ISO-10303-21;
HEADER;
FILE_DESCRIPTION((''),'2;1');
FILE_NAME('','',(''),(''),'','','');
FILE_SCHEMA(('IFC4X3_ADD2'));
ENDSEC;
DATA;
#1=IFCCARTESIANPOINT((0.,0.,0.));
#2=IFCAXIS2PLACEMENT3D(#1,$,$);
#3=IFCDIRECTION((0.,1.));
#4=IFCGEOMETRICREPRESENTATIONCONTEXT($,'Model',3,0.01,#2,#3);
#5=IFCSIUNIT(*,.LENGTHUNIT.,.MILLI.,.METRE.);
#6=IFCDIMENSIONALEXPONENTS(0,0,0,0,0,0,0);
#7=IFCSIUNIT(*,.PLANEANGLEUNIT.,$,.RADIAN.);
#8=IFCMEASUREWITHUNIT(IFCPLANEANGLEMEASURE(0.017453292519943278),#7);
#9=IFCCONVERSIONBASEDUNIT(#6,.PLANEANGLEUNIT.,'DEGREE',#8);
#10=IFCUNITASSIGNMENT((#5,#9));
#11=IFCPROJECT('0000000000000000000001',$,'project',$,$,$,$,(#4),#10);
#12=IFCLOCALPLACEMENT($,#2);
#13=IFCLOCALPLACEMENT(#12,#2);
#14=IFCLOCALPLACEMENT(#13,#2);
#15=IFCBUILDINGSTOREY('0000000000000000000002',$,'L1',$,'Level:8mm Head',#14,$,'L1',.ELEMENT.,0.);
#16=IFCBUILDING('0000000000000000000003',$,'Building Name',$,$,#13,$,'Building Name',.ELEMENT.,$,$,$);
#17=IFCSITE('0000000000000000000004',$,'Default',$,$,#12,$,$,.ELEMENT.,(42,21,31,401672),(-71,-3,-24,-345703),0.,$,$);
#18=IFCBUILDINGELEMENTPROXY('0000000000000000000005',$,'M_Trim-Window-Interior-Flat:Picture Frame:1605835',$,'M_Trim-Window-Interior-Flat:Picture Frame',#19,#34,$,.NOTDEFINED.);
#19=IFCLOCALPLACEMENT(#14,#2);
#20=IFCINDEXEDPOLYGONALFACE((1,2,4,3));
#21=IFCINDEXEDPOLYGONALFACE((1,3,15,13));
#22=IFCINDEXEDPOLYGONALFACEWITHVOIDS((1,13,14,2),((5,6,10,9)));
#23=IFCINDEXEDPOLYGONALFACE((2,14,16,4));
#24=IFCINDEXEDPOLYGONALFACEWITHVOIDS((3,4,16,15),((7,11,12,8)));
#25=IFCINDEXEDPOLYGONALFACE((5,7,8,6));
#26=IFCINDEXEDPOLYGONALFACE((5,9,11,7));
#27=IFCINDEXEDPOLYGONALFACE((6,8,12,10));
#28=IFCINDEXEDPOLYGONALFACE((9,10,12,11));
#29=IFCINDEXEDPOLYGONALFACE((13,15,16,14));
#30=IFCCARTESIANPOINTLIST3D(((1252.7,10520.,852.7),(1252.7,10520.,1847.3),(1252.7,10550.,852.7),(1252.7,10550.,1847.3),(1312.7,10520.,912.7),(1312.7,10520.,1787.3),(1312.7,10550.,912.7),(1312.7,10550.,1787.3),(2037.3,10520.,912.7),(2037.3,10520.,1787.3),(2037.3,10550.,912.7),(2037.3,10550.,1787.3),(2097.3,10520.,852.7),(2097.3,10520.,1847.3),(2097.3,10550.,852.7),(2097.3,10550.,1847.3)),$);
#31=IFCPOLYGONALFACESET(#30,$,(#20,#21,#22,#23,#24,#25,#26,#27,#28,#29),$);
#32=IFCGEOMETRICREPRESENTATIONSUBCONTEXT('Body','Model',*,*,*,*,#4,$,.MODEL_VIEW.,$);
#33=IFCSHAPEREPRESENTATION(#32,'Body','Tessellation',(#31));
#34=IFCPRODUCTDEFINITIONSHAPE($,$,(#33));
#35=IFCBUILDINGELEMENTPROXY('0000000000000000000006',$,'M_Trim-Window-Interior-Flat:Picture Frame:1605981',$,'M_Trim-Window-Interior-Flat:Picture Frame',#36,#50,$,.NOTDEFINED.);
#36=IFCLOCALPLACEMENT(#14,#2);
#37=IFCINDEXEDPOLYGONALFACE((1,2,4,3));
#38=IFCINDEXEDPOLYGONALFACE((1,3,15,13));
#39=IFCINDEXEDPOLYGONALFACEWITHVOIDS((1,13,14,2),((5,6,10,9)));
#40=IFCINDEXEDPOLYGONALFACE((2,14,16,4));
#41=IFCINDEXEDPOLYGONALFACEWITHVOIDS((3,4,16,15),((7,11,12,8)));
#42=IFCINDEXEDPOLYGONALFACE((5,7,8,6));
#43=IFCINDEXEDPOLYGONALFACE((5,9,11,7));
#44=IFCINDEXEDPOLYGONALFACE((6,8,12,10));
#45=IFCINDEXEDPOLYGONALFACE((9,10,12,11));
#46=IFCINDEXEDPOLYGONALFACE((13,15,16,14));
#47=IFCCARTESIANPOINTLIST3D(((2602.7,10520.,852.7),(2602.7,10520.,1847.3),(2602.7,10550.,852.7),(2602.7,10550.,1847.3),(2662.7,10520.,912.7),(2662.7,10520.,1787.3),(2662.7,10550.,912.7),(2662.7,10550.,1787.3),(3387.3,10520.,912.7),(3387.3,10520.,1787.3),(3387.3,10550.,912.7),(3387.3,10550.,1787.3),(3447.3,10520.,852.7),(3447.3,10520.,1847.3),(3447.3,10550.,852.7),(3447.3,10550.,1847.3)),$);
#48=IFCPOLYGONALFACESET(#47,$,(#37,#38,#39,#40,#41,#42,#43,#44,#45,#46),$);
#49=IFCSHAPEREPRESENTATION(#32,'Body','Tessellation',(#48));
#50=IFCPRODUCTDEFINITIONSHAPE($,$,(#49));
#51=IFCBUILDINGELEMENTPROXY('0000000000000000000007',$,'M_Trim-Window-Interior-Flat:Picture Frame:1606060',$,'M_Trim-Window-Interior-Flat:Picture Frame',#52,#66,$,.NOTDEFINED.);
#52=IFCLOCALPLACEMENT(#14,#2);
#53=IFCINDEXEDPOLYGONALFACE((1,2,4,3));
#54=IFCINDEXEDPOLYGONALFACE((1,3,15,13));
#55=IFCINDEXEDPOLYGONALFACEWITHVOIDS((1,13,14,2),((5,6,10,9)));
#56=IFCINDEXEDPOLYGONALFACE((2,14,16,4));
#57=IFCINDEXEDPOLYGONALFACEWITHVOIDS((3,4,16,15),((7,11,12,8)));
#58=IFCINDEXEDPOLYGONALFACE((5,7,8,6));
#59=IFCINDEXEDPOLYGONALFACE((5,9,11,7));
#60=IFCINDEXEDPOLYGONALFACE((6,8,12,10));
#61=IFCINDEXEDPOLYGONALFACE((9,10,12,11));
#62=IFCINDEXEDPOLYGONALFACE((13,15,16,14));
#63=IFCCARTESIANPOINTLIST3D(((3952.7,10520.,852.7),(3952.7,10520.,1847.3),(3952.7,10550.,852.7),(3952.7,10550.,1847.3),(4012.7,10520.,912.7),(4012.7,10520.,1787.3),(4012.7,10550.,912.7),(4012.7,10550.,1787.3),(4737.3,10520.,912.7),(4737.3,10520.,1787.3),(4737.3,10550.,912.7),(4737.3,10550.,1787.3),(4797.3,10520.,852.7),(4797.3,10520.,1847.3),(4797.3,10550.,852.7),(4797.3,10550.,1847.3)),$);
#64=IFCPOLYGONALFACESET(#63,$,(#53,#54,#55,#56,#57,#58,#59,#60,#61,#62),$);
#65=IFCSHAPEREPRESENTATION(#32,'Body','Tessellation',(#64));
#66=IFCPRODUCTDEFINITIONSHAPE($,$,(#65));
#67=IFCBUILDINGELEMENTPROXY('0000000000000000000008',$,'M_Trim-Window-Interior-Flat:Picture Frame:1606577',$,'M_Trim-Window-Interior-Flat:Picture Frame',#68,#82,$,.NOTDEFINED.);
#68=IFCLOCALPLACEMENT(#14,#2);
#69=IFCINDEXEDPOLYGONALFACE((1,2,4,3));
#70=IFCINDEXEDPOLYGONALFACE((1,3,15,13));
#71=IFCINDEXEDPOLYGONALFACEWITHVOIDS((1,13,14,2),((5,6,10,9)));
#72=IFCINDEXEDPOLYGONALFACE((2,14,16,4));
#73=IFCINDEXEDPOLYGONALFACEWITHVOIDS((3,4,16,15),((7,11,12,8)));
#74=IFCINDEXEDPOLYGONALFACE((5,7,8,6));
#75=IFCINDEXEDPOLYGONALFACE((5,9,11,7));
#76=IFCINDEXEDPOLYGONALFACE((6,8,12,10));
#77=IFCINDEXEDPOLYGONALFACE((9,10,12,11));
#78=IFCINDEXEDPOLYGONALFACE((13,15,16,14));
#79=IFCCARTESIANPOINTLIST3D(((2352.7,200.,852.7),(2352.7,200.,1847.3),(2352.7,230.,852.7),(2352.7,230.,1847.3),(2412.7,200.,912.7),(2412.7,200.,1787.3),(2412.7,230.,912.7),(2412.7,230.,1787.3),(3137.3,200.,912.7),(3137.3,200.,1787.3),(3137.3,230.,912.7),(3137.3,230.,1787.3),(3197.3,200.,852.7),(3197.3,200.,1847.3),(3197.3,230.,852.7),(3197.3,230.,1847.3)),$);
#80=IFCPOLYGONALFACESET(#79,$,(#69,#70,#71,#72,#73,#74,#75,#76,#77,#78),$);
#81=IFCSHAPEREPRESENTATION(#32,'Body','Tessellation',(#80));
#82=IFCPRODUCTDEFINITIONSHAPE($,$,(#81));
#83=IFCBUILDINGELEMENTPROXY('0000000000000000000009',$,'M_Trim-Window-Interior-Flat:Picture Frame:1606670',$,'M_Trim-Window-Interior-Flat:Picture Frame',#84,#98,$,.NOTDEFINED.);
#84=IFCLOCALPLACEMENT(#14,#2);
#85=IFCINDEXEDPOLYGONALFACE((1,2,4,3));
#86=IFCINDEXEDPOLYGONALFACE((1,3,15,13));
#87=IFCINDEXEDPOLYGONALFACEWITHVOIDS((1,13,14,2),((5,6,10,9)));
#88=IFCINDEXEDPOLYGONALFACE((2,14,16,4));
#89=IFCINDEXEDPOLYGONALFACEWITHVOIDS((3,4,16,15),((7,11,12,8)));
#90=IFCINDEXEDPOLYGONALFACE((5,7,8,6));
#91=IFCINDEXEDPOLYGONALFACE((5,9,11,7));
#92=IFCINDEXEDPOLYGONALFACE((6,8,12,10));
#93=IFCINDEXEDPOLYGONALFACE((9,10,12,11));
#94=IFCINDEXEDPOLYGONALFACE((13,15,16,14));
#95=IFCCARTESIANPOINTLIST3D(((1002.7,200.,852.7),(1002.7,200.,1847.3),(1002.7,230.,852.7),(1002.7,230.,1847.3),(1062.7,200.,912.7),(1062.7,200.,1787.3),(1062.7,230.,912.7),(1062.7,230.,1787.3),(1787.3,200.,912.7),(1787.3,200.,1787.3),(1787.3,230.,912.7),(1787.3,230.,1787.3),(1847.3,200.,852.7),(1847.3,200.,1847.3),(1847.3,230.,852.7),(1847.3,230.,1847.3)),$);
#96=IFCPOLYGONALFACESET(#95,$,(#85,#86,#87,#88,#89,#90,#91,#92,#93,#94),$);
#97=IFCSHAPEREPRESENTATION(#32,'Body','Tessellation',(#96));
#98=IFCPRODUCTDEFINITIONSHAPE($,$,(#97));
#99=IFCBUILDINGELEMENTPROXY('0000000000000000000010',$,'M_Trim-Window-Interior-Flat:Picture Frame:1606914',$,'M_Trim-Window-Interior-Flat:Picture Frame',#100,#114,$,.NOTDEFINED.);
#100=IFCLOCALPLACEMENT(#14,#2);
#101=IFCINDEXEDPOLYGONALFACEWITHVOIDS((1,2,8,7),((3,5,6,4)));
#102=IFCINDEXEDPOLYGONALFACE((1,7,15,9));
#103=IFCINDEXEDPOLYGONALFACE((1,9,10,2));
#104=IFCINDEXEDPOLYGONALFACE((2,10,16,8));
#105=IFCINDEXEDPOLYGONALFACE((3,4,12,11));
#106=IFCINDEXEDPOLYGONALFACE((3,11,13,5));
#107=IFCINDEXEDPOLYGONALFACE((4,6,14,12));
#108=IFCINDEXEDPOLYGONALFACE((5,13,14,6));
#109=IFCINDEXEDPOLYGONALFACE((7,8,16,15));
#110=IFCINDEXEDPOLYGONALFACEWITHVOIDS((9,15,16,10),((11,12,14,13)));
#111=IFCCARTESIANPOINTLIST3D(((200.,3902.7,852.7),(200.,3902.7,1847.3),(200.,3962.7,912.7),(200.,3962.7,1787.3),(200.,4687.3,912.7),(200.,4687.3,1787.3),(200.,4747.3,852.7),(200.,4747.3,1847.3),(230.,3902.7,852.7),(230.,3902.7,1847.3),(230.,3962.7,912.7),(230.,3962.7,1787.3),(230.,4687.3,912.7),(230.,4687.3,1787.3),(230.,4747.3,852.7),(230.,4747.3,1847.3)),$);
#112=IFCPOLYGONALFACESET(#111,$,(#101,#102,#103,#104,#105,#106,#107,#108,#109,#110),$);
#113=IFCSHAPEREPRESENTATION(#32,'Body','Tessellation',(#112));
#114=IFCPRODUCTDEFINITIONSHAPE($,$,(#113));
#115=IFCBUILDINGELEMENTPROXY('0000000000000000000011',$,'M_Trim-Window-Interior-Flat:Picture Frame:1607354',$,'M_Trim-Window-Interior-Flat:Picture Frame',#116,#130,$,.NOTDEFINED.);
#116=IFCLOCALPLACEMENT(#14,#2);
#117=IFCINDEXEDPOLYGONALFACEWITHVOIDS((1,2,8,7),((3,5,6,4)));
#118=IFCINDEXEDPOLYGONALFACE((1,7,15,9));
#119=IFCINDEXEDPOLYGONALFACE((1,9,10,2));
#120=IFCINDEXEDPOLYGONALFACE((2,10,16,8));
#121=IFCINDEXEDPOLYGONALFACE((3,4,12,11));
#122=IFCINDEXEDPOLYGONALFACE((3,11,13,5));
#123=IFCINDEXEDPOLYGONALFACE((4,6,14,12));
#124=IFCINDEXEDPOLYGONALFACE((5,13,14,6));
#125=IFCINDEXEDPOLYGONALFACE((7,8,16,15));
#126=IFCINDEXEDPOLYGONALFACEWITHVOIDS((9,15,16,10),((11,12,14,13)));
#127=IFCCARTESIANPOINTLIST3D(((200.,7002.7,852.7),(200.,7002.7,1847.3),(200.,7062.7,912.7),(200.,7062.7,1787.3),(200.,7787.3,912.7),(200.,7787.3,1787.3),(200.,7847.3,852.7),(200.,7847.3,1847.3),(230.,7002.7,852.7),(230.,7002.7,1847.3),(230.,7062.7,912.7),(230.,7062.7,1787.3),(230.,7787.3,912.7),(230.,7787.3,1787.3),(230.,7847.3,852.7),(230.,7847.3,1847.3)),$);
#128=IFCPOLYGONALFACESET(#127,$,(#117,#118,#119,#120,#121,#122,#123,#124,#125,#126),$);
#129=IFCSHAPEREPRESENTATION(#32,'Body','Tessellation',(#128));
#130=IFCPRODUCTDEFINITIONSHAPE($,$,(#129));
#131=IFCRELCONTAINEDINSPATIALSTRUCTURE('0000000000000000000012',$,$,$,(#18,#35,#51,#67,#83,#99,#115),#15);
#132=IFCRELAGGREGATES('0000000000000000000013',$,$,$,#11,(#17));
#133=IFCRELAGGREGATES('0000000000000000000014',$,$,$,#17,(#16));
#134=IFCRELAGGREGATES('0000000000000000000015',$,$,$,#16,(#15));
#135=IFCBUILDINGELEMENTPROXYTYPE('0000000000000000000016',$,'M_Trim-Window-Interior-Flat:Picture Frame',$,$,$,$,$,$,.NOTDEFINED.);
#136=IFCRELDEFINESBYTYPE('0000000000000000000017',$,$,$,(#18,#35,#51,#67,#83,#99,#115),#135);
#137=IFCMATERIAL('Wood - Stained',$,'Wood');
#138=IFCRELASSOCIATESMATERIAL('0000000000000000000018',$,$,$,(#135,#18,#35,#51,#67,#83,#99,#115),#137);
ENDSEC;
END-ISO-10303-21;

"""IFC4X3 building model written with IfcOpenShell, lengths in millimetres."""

from ifc_helpers import new_model, entity, si_unit, converted_unit, direction, frame, origin, place, context, subcontext, project, spatial, polyline, outline, extrude, source, transform, mapped, material, type_object, type_shapes, element, save


model = new_model("IFC4X3")

# Units and contexts
model_context = context("Model", 3, precision=0.01, world=origin(), true_north=direction((0.0, 1.0)))
body_context = subcontext(model_context, "Body", "Model", "MODEL_VIEW")
ifc_project = project(units=[si_unit("LENGTHUNIT", "METRE", prefix="MILLI"), converted_unit("PLANEANGLEUNIT", "DEGREE", entity("IfcPlaneAngleMeasure", 0.017453292519943278), si_unit("PLANEANGLEUNIT", "RADIAN"), dimensions=[0, 0, 0, 0, 0, 0, 0])], contexts=[model_context])

# Site, building, storey
site_placement = place(None, origin())
site = spatial("IfcSite", under=ifc_project, at=site_placement, Name="Default", CompositionType="ELEMENT", RefLatitude=(42, 21, 31, 401672), RefLongitude=(-71, -3, -24, -345703), RefElevation=0.0)
building_placement = place(site_placement, origin())
building = spatial("IfcBuilding", under=site, at=building_placement, Name="Building Name", LongName="Building Name", CompositionType="ELEMENT")
storey_placement = place(building_placement, origin())
storey = spatial("IfcBuildingStorey", under=building, at=storey_placement, Name="L1", ObjectType="Level:8mm Head", LongName="L1", CompositionType="ELEMENT", Elevation=0.0)

# Building element proxies
ifc_material_1 = material(Name="Wood - Stained", Category="Wood")
building_element_proxy_type_1 = type_object("IfcBuildingElementProxyType", Name="M_Trim-Window-Interior-Flat:Picture Frame", PredefinedType="NOTDEFINED", material=ifc_material_1)
shared_shape_1 = source(origin(), body_context, "Body", "SweptSolid", [
    extrude(outline(polyline([(-422.3, -497.3), (422.3, -497.3), (422.3, 497.3), (-422.3, 497.3), (-422.3, -497.3)]), holes=[polyline([(-362.3, -437.3), (-362.3, 437.3), (362.3, 437.3), (362.3, -437.3), (-362.3, -437.3)])]), frame((0.0, -450.0, 0.0), z_axis=(0.0, 0.0, 1.0), x_axis=(-1.0, 0.0, 0.0)), (0.0, 0.0, 1.0), 30.0),
])
type_shapes(building_element_proxy_type_1, [shared_shape_1])
for number, where, z_axis, x_axis, name in (
    (1, (1675.0, 10550.0, 1800.0), (0.0, -1.0, 0.0), (1.0, 0.0, 0.0), "M_Trim-Window-Interior-Flat:Picture Frame:1605835"),
    (2, (3025.0, 10550.0, 1800.0), (0.0, -1.0, 0.0), (1.0, 0.0, 0.0), "M_Trim-Window-Interior-Flat:Picture Frame:1605981"),
    (3, (4375.0, 10550.0, 1800.0), (0.0, -1.0, 0.0), (1.0, 0.0, 0.0), "M_Trim-Window-Interior-Flat:Picture Frame:1606060"),
    (4, (2775.0, 200.0, 1800.0), (0.0, 1.0, 0.0), (-1.0, 0.0, 0.0), "M_Trim-Window-Interior-Flat:Picture Frame:1606577"),
    (5, (1425.0, 200.0, 1800.0), (0.0, 1.0, 0.0), (-1.0, 0.0, 0.0), "M_Trim-Window-Interior-Flat:Picture Frame:1606670"),
    (6, (200.0, 4325.0, 1800.0), (1.0, 0.0, 0.0), (0.0, 1.0, 0.0), "M_Trim-Window-Interior-Flat:Picture Frame:1606914"),
    (7, (200.0, 7425.0, 1800.0), (1.0, 0.0, 0.0), (0.0, 1.0, 0.0), "M_Trim-Window-Interior-Flat:Picture Frame:1607354"),
):
    element("IfcBuildingElementProxy", number, at=place(storey_placement, frame(where, z_axis=z_axis, x_axis=x_axis)), inside=storey, type_object=building_element_proxy_type_1, material=ifc_material_1, Name=name, ObjectType="M_Trim-Window-Interior-Flat:Picture Frame", PredefinedType="NOTDEFINED", context=body_context, shape_type="MappedRepresentation", body=[
        mapped(shared_shape_1, transform((0.0, 0.0, 0.0), scale=1.0)),
    ])

save(model, "model.ifc")
